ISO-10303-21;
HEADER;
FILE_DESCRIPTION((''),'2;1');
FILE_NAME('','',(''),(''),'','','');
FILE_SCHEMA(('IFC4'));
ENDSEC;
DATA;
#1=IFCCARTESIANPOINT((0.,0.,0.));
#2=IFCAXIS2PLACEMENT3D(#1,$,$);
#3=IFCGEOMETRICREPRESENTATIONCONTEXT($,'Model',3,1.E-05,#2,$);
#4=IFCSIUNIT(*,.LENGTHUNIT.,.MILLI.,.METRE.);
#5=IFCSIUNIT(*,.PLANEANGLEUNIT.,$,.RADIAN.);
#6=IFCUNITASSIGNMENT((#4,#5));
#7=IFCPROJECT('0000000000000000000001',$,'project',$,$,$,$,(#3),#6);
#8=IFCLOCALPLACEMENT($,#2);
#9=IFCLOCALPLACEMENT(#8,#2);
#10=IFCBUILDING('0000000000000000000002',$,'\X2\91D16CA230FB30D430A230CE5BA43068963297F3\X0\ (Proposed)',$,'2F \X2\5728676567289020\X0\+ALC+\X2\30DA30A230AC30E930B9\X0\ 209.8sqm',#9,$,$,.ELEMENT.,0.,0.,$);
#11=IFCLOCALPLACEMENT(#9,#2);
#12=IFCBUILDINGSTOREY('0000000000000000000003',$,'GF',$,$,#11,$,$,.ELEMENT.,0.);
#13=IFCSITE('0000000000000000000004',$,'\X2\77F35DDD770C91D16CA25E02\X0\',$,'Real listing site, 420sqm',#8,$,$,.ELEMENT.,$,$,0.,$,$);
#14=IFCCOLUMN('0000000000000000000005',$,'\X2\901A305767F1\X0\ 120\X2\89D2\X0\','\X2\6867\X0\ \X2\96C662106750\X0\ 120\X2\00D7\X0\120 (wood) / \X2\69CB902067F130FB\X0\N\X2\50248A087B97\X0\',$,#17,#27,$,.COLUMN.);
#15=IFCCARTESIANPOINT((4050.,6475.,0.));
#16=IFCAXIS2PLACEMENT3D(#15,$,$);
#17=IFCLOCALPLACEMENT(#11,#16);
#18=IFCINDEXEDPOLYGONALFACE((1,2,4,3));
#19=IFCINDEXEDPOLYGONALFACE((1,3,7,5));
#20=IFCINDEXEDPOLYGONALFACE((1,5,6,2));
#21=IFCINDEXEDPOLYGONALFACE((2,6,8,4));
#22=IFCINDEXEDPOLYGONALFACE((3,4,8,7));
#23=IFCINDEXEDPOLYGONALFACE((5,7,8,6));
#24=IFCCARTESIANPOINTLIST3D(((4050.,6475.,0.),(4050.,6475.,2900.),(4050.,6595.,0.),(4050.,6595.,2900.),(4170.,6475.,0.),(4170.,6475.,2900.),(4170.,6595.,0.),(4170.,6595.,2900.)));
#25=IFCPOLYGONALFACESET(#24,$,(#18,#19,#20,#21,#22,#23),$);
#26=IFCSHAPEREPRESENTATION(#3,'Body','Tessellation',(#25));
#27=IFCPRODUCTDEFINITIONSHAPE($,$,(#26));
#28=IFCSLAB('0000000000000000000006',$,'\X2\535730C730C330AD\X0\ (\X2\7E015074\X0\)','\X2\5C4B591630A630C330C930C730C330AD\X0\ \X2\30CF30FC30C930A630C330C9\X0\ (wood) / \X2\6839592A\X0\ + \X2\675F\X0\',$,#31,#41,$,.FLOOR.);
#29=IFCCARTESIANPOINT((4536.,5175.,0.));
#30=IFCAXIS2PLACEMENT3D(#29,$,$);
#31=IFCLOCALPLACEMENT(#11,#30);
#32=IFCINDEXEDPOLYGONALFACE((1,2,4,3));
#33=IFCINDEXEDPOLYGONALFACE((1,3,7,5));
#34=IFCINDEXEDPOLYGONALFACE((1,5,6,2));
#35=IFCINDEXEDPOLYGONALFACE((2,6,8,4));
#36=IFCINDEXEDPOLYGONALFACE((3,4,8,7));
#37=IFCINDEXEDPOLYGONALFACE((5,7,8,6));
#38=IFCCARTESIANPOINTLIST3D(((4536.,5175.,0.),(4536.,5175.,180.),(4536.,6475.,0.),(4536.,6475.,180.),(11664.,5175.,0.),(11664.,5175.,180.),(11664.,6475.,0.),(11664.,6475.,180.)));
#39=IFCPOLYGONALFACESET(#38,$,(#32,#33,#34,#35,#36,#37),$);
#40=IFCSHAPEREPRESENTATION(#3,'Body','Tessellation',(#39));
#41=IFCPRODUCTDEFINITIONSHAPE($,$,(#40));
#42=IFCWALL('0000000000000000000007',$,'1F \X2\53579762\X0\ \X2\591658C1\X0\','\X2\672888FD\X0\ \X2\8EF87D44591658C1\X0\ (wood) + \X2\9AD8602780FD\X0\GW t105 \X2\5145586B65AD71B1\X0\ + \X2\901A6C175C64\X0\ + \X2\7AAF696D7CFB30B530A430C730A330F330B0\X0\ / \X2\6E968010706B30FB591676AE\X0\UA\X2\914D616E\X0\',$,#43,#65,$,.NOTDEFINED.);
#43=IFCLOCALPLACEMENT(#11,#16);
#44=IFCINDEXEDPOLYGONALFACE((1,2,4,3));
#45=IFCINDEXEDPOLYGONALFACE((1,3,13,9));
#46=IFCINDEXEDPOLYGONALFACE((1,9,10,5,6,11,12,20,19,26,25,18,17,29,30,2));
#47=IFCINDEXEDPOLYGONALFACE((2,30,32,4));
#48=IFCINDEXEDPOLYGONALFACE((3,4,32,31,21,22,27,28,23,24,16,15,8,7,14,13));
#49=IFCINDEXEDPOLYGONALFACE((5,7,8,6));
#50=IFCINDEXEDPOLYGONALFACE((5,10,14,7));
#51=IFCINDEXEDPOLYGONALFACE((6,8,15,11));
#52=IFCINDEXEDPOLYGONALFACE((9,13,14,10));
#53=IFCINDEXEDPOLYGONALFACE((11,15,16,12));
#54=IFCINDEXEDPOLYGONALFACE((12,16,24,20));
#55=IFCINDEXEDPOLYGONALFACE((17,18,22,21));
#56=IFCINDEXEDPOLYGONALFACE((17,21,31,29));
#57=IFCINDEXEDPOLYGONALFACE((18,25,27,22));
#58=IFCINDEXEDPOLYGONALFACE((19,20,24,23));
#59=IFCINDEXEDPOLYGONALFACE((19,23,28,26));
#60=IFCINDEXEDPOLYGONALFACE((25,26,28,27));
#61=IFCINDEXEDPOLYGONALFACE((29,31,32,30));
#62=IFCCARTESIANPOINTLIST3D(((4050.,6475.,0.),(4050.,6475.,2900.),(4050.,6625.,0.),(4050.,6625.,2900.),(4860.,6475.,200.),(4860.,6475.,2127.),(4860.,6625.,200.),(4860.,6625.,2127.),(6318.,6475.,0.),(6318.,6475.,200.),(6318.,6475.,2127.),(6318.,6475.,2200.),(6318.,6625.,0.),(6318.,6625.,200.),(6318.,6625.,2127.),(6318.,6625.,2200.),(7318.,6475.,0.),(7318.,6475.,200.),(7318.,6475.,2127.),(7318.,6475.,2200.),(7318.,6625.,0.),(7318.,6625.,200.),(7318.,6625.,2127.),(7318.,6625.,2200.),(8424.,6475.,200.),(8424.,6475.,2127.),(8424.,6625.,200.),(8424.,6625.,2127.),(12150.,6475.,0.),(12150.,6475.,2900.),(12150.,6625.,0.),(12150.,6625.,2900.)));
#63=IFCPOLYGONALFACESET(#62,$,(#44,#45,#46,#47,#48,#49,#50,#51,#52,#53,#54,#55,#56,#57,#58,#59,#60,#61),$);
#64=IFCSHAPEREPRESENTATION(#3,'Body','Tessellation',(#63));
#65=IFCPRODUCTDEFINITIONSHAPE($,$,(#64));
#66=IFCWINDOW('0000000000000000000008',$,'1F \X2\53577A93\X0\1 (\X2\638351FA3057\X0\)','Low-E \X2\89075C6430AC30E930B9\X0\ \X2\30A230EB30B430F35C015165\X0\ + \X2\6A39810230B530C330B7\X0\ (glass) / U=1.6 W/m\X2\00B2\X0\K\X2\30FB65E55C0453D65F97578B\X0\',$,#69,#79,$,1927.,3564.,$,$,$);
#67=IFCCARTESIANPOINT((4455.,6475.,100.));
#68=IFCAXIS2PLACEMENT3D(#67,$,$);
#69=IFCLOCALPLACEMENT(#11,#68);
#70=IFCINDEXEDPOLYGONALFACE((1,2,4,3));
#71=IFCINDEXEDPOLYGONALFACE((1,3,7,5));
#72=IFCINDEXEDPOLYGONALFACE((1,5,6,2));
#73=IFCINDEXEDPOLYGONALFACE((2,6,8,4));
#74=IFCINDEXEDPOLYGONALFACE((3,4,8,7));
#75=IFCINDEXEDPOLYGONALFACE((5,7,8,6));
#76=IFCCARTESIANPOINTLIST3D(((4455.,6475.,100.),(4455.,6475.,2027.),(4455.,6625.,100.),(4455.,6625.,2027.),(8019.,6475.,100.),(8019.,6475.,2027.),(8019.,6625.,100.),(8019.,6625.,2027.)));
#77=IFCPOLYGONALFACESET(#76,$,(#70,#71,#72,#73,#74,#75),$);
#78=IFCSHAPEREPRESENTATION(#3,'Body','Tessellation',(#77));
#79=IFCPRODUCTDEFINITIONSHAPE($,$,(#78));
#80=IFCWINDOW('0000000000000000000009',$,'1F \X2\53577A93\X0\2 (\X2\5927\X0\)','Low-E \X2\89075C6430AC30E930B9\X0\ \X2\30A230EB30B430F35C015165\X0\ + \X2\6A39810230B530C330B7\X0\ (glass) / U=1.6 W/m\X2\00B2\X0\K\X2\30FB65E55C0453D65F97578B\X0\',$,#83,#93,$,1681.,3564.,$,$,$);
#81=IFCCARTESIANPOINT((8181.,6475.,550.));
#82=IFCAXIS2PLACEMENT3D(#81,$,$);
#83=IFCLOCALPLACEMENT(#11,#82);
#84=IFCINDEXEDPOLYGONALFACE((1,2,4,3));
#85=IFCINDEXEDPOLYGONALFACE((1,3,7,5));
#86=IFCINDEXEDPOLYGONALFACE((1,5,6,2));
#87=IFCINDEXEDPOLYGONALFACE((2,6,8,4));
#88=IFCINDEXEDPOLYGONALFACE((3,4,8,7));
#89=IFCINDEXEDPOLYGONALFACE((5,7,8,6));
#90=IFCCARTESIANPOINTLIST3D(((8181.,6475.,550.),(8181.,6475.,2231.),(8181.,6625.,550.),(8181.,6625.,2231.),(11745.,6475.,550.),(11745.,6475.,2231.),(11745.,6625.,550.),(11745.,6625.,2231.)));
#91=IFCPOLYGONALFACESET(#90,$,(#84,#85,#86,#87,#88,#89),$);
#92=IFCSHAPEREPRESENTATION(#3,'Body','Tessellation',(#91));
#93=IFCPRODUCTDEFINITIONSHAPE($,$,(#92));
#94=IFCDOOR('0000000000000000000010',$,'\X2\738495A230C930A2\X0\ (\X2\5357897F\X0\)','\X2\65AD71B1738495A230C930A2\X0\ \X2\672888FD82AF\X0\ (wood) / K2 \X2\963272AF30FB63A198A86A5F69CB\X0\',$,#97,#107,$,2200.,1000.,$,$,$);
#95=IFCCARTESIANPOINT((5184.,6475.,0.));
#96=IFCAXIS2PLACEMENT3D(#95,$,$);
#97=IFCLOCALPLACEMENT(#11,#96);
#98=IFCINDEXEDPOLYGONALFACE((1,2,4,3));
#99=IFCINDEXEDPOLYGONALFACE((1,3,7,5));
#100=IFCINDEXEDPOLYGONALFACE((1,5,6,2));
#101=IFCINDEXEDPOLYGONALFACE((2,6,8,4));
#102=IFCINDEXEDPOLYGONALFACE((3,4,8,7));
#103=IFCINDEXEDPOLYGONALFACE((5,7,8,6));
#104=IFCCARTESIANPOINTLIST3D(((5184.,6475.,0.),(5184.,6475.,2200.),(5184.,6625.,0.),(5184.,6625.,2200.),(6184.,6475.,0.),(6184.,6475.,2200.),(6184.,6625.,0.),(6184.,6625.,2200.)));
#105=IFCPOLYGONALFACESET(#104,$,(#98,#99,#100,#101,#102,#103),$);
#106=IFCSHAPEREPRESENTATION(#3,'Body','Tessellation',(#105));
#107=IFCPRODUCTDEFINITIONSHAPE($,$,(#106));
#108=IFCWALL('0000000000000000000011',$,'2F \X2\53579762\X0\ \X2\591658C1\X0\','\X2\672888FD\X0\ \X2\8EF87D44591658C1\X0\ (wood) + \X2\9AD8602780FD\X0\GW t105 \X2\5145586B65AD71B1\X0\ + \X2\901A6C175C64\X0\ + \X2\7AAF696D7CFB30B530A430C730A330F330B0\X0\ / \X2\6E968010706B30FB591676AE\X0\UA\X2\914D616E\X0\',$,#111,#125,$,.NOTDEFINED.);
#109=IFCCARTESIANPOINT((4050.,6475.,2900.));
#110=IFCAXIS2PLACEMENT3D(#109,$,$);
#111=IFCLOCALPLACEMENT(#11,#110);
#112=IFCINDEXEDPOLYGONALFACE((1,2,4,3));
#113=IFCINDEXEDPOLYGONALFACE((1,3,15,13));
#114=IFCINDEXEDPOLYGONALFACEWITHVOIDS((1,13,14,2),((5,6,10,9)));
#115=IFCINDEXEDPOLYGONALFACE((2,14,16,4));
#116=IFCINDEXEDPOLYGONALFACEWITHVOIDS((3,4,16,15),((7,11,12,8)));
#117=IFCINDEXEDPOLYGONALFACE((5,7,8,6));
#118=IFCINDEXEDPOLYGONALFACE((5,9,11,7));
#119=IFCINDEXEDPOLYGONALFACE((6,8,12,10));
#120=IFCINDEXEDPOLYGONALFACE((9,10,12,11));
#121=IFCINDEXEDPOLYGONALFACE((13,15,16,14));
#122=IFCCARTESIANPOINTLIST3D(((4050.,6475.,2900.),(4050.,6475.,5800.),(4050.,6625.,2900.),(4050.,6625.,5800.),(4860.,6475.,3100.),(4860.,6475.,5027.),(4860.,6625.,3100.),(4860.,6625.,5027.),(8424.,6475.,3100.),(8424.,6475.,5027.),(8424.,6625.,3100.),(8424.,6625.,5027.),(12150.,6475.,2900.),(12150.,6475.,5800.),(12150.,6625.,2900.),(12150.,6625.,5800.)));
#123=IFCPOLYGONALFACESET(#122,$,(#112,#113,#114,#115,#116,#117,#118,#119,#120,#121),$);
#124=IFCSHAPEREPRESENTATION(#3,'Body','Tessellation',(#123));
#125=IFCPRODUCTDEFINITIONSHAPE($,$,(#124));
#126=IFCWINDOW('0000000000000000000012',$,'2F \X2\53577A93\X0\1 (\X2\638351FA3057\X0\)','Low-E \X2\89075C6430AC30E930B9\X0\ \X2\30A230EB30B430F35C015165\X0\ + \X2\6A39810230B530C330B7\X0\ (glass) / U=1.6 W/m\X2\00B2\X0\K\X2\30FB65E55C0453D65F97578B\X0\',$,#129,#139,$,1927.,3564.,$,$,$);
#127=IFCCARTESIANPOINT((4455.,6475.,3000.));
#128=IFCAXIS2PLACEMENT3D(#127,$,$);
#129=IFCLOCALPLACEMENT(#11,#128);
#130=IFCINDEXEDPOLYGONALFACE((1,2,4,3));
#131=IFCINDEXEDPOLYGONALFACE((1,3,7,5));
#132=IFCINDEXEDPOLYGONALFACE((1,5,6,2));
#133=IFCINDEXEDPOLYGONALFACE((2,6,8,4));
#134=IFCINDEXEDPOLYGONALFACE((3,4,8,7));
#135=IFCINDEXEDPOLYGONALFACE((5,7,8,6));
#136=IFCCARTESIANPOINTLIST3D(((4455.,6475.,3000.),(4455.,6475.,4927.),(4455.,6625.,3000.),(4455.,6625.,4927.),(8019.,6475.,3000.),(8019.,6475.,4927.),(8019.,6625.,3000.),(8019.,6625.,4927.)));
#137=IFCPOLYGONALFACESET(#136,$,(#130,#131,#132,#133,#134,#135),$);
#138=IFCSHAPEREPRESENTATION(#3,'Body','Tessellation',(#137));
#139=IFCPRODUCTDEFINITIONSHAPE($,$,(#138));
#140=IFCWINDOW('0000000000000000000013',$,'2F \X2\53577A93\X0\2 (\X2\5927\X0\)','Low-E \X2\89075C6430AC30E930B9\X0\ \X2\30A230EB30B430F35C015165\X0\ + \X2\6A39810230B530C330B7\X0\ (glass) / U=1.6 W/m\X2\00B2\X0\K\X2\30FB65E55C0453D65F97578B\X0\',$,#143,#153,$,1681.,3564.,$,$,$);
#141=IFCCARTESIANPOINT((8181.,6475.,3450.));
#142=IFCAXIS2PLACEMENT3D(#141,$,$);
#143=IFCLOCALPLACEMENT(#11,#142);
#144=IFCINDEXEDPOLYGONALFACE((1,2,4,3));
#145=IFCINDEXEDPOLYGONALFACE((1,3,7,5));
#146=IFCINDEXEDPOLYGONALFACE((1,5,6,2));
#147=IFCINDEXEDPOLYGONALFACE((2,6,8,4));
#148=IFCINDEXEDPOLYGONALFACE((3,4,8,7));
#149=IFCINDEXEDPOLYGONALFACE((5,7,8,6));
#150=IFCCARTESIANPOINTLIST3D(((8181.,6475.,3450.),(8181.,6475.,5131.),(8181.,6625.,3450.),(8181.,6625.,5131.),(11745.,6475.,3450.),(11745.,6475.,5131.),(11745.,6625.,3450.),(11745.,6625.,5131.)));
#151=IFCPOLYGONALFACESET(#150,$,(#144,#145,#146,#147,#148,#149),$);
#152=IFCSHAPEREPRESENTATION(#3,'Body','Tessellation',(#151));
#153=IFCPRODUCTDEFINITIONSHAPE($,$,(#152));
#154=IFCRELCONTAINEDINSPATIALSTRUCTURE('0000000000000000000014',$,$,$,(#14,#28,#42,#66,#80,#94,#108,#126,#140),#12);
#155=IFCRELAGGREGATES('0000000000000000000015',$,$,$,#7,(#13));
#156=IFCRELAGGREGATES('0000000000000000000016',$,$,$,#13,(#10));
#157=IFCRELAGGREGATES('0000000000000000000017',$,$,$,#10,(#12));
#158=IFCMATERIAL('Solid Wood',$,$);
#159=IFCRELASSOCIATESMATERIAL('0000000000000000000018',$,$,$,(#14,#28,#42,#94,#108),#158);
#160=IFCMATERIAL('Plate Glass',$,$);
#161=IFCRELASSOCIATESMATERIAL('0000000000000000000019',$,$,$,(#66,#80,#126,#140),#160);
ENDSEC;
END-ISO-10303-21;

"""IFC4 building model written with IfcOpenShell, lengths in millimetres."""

from ifc_helpers import new_model, si_unit, frame, frame_2d, origin, place, context, project, spatial, rectangle, extrude, material, element, fill, save


model = new_model("IFC4")

# Units and contexts
model_context = context("Model", 3, precision=1e-05, world=origin())
ifc_project = project(units=[si_unit("LENGTHUNIT", "METRE", prefix="MILLI"), si_unit("PLANEANGLEUNIT", "RADIAN")], contexts=[model_context])

# Site, building, storey
site_placement = place(None, origin())
site = spatial("IfcSite", under=ifc_project, at=site_placement, Name="石川県金沢市", ObjectType="Real listing site, 420sqm", CompositionType="ELEMENT", RefElevation=0.0)
building_placement = place(site_placement, origin())
building = spatial("IfcBuilding", under=site, at=building_placement, Name="金沢・ピアノ室と防音 (Proposed)", ObjectType="2F 在来木造+ALC+ペアガラス 209.8sqm", CompositionType="ELEMENT", ElevationOfRefHeight=0.0, ElevationOfTerrain=0.0)
storey_placement = place(building_placement, origin())
storey = spatial("IfcBuildingStorey", under=building, at=storey_placement, Name="GF", CompositionType="ELEMENT", Elevation=0.0)

# Column
ifc_material_1 = material(Name="Solid Wood")
column_placement = place(storey_placement, frame((4050.0, 6475.0, 0.0)))
element("IfcColumn", 1, at=column_placement, inside=storey, material=ifc_material_1, Name="通し柱 120角", Description="桧 集成材 120×120 (wood) / 構造柱・N値計算", PredefinedType="COLUMN", context=model_context, shape_type="SweptSolid", body=[
    extrude(rectangle(XDim=120.0, YDim=120.0, at=frame_2d((60.0, 60.0))), frame((4050.0, 6475.0, 0.0)), (0.0, 0.0, 1.0), 2900.0),
])

# Slab
slab_1_placement = place(storey_placement, frame((4536.0, 5175.0, 0.0)))
element("IfcSlab", 2, at=slab_1_placement, inside=storey, material=ifc_material_1, Name="南デッキ (縁側)", Description="屋外ウッドデッキ ハードウッド (wood) / 根太 + 束", PredefinedType="FLOOR", context=model_context, shape_type="SweptSolid", body=[
    extrude(rectangle(XDim=7128.0, YDim=1300.0, at=frame_2d((3564.0, 650.0))), frame((4536.0, 5175.0, 0.0)), (0.0, 0.0, 1.0), 180.0),
])

# Wall, openings, windows, door
wall_1_placement = place(storey_placement, frame((4050.0, 6475.0, 0.0)))
wall_1 = element("IfcWall", 3, at=wall_1_placement, inside=storey, material=ifc_material_1, Name="1F 南面 外壁", Description="木製 軸組外壁 (wood) + 高性能GW t105 充填断熱 + 通気層 + 窯業系サイディング / 準耐火・外皮UA配慮", PredefinedType="NOTDEFINED", context=model_context, shape_type="SweptSolid", body=[
    extrude(rectangle(XDim=8100.0, YDim=150.0, at=frame_2d((4050.0, 75.0))), frame((4050.0, 6475.0, 0.0)), (0.0, 0.0, 1.0), 2900.0),
])
opening_1_placement = place(storey_placement, frame((4455.0, 6475.0, 100.0)))
opening_1 = element("IfcOpeningElement", 4, at=opening_1_placement, cuts=wall_1, PredefinedType="NOTDEFINED", context=model_context, shape_type="SweptSolid", body=[
    extrude(rectangle(XDim=3564.0, YDim=150.0, at=frame_2d((1782.0, 75.0))), frame((4455.0, 6475.0, 100.0)), (0.0, 0.0, 1.0), 1927.0),
])
opening_2_placement = place(storey_placement, frame((8181.0, 6475.0, 550.0)))
opening_2 = element("IfcOpeningElement", 5, at=opening_2_placement, cuts=wall_1, PredefinedType="NOTDEFINED", context=model_context, shape_type="SweptSolid", body=[
    extrude(rectangle(XDim=3564.0, YDim=150.0, at=frame_2d((1782.0, 75.0))), frame((8181.0, 6475.0, 550.0)), (0.0, 0.0, 1.0), 1681.0),
])
opening_3_placement = place(storey_placement, frame((5184.0, 6475.0, 0.0)))
opening_3 = element("IfcOpeningElement", 6, at=opening_3_placement, cuts=wall_1, PredefinedType="NOTDEFINED", context=model_context, shape_type="SweptSolid", body=[
    extrude(rectangle(XDim=1000.0, YDim=150.0, at=frame_2d((500.0, 75.0))), frame((5184.0, 6475.0, 0.0)), (0.0, 0.0, 1.0), 2200.0),
])
ifc_material_2 = material(Name="Plate Glass")
window_1_placement = place(storey_placement, frame((4455.0, 6475.0, 100.0)))
window_1 = element("IfcWindow", 7, at=window_1_placement, inside=storey, material=ifc_material_2, Name="1F 南窓1 (掃出し)", Description="Low-E 複層ガラス アルゴン封入 + 樹脂サッシ (glass) / U=1.6 W/m²K・日射取得型", OverallHeight=1927.0, OverallWidth=3564.0, context=model_context, shape_type="SweptSolid", body=[
    extrude(rectangle(XDim=3564.0, YDim=150.0, at=frame_2d((1782.0, 75.0))), frame((4455.0, 6475.0, 100.0)), (0.0, 0.0, 1.0), 1927.0),
])
fill(opening_1, window_1)
window_2_placement = place(storey_placement, frame((8181.0, 6475.0, 550.0)))
window_2 = element("IfcWindow", 8, at=window_2_placement, inside=storey, material=ifc_material_2, Name="1F 南窓2 (大)", Description="Low-E 複層ガラス アルゴン封入 + 樹脂サッシ (glass) / U=1.6 W/m²K・日射取得型", OverallHeight=1681.0, OverallWidth=3564.0, context=model_context, shape_type="SweptSolid", body=[
    extrude(rectangle(XDim=3564.0, YDim=150.0, at=frame_2d((1782.0, 75.0))), frame((8181.0, 6475.0, 550.0)), (0.0, 0.0, 1.0), 1681.0),
])
fill(opening_2, window_2)
door_placement = place(storey_placement, frame((5184.0, 6475.0, 0.0)))
door = element("IfcDoor", 9, at=door_placement, inside=storey, material=ifc_material_1, Name="玄関ドア (南西)", Description="断熱玄関ドア 木製芯 (wood) / K2 防犯・採風機構", OverallHeight=2200.0, OverallWidth=1000.0, context=model_context, shape_type="SweptSolid", body=[
    extrude(rectangle(XDim=1000.0, YDim=150.0, at=frame_2d((500.0, 75.0))), frame((5184.0, 6475.0, 0.0)), (0.0, 0.0, 1.0), 2200.0),
])
fill(opening_3, door)

# Wall, openings, windows
wall_2_placement = place(storey_placement, frame((4050.0, 6475.0, 2900.0)))
wall_2 = element("IfcWall", 10, at=wall_2_placement, inside=storey, material=ifc_material_1, Name="2F 南面 外壁", Description="木製 軸組外壁 (wood) + 高性能GW t105 充填断熱 + 通気層 + 窯業系サイディング / 準耐火・外皮UA配慮", PredefinedType="NOTDEFINED", context=model_context, shape_type="SweptSolid", body=[
    extrude(rectangle(XDim=8100.0, YDim=150.0, at=frame_2d((4050.0, 75.0))), frame((4050.0, 6475.0, 2900.0)), (0.0, 0.0, 1.0), 2900.0),
])
opening_4_placement = place(storey_placement, frame((4455.0, 6475.0, 3000.0)))
opening_4 = element("IfcOpeningElement", 11, at=opening_4_placement, cuts=wall_2, PredefinedType="NOTDEFINED", context=model_context, shape_type="SweptSolid", body=[
    extrude(rectangle(XDim=3564.0, YDim=150.0, at=frame_2d((1782.0, 75.0))), frame((4455.0, 6475.0, 3000.0)), (0.0, 0.0, 1.0), 1927.0),
])
opening_5_placement = place(storey_placement, frame((8181.0, 6475.0, 3450.0)))
opening_5 = element("IfcOpeningElement", 12, at=opening_5_placement, cuts=wall_2, PredefinedType="NOTDEFINED", context=model_context, shape_type="SweptSolid", body=[
    extrude(rectangle(XDim=3564.0, YDim=150.0, at=frame_2d((1782.0, 75.0))), frame((8181.0, 6475.0, 3450.0)), (0.0, 0.0, 1.0), 1681.0),
])
window_3_placement = place(storey_placement, frame((4455.0, 6475.0, 3000.0)))
window_3 = element("IfcWindow", 13, at=window_3_placement, inside=storey, material=ifc_material_2, Name="2F 南窓1 (掃出し)", Description="Low-E 複層ガラス アルゴン封入 + 樹脂サッシ (glass) / U=1.6 W/m²K・日射取得型", OverallHeight=1927.0, OverallWidth=3564.0, context=model_context, shape_type="SweptSolid", body=[
    extrude(rectangle(XDim=3564.0, YDim=150.0, at=frame_2d((1782.0, 75.0))), frame((4455.0, 6475.0, 3000.0)), (0.0, 0.0, 1.0), 1927.0),
])
fill(opening_4, window_3)
window_4_placement = place(storey_placement, frame((8181.0, 6475.0, 3450.0)))
window_4 = element("IfcWindow", 14, at=window_4_placement, inside=storey, material=ifc_material_2, Name="2F 南窓2 (大)", Description="Low-E 複層ガラス アルゴン封入 + 樹脂サッシ (glass) / U=1.6 W/m²K・日射取得型", OverallHeight=1681.0, OverallWidth=3564.0, context=model_context, shape_type="SweptSolid", body=[
    extrude(rectangle(XDim=3564.0, YDim=150.0, at=frame_2d((1782.0, 75.0))), frame((8181.0, 6475.0, 3450.0)), (0.0, 0.0, 1.0), 1681.0),
])
fill(opening_5, window_4)

save(model, "model.ifc")
